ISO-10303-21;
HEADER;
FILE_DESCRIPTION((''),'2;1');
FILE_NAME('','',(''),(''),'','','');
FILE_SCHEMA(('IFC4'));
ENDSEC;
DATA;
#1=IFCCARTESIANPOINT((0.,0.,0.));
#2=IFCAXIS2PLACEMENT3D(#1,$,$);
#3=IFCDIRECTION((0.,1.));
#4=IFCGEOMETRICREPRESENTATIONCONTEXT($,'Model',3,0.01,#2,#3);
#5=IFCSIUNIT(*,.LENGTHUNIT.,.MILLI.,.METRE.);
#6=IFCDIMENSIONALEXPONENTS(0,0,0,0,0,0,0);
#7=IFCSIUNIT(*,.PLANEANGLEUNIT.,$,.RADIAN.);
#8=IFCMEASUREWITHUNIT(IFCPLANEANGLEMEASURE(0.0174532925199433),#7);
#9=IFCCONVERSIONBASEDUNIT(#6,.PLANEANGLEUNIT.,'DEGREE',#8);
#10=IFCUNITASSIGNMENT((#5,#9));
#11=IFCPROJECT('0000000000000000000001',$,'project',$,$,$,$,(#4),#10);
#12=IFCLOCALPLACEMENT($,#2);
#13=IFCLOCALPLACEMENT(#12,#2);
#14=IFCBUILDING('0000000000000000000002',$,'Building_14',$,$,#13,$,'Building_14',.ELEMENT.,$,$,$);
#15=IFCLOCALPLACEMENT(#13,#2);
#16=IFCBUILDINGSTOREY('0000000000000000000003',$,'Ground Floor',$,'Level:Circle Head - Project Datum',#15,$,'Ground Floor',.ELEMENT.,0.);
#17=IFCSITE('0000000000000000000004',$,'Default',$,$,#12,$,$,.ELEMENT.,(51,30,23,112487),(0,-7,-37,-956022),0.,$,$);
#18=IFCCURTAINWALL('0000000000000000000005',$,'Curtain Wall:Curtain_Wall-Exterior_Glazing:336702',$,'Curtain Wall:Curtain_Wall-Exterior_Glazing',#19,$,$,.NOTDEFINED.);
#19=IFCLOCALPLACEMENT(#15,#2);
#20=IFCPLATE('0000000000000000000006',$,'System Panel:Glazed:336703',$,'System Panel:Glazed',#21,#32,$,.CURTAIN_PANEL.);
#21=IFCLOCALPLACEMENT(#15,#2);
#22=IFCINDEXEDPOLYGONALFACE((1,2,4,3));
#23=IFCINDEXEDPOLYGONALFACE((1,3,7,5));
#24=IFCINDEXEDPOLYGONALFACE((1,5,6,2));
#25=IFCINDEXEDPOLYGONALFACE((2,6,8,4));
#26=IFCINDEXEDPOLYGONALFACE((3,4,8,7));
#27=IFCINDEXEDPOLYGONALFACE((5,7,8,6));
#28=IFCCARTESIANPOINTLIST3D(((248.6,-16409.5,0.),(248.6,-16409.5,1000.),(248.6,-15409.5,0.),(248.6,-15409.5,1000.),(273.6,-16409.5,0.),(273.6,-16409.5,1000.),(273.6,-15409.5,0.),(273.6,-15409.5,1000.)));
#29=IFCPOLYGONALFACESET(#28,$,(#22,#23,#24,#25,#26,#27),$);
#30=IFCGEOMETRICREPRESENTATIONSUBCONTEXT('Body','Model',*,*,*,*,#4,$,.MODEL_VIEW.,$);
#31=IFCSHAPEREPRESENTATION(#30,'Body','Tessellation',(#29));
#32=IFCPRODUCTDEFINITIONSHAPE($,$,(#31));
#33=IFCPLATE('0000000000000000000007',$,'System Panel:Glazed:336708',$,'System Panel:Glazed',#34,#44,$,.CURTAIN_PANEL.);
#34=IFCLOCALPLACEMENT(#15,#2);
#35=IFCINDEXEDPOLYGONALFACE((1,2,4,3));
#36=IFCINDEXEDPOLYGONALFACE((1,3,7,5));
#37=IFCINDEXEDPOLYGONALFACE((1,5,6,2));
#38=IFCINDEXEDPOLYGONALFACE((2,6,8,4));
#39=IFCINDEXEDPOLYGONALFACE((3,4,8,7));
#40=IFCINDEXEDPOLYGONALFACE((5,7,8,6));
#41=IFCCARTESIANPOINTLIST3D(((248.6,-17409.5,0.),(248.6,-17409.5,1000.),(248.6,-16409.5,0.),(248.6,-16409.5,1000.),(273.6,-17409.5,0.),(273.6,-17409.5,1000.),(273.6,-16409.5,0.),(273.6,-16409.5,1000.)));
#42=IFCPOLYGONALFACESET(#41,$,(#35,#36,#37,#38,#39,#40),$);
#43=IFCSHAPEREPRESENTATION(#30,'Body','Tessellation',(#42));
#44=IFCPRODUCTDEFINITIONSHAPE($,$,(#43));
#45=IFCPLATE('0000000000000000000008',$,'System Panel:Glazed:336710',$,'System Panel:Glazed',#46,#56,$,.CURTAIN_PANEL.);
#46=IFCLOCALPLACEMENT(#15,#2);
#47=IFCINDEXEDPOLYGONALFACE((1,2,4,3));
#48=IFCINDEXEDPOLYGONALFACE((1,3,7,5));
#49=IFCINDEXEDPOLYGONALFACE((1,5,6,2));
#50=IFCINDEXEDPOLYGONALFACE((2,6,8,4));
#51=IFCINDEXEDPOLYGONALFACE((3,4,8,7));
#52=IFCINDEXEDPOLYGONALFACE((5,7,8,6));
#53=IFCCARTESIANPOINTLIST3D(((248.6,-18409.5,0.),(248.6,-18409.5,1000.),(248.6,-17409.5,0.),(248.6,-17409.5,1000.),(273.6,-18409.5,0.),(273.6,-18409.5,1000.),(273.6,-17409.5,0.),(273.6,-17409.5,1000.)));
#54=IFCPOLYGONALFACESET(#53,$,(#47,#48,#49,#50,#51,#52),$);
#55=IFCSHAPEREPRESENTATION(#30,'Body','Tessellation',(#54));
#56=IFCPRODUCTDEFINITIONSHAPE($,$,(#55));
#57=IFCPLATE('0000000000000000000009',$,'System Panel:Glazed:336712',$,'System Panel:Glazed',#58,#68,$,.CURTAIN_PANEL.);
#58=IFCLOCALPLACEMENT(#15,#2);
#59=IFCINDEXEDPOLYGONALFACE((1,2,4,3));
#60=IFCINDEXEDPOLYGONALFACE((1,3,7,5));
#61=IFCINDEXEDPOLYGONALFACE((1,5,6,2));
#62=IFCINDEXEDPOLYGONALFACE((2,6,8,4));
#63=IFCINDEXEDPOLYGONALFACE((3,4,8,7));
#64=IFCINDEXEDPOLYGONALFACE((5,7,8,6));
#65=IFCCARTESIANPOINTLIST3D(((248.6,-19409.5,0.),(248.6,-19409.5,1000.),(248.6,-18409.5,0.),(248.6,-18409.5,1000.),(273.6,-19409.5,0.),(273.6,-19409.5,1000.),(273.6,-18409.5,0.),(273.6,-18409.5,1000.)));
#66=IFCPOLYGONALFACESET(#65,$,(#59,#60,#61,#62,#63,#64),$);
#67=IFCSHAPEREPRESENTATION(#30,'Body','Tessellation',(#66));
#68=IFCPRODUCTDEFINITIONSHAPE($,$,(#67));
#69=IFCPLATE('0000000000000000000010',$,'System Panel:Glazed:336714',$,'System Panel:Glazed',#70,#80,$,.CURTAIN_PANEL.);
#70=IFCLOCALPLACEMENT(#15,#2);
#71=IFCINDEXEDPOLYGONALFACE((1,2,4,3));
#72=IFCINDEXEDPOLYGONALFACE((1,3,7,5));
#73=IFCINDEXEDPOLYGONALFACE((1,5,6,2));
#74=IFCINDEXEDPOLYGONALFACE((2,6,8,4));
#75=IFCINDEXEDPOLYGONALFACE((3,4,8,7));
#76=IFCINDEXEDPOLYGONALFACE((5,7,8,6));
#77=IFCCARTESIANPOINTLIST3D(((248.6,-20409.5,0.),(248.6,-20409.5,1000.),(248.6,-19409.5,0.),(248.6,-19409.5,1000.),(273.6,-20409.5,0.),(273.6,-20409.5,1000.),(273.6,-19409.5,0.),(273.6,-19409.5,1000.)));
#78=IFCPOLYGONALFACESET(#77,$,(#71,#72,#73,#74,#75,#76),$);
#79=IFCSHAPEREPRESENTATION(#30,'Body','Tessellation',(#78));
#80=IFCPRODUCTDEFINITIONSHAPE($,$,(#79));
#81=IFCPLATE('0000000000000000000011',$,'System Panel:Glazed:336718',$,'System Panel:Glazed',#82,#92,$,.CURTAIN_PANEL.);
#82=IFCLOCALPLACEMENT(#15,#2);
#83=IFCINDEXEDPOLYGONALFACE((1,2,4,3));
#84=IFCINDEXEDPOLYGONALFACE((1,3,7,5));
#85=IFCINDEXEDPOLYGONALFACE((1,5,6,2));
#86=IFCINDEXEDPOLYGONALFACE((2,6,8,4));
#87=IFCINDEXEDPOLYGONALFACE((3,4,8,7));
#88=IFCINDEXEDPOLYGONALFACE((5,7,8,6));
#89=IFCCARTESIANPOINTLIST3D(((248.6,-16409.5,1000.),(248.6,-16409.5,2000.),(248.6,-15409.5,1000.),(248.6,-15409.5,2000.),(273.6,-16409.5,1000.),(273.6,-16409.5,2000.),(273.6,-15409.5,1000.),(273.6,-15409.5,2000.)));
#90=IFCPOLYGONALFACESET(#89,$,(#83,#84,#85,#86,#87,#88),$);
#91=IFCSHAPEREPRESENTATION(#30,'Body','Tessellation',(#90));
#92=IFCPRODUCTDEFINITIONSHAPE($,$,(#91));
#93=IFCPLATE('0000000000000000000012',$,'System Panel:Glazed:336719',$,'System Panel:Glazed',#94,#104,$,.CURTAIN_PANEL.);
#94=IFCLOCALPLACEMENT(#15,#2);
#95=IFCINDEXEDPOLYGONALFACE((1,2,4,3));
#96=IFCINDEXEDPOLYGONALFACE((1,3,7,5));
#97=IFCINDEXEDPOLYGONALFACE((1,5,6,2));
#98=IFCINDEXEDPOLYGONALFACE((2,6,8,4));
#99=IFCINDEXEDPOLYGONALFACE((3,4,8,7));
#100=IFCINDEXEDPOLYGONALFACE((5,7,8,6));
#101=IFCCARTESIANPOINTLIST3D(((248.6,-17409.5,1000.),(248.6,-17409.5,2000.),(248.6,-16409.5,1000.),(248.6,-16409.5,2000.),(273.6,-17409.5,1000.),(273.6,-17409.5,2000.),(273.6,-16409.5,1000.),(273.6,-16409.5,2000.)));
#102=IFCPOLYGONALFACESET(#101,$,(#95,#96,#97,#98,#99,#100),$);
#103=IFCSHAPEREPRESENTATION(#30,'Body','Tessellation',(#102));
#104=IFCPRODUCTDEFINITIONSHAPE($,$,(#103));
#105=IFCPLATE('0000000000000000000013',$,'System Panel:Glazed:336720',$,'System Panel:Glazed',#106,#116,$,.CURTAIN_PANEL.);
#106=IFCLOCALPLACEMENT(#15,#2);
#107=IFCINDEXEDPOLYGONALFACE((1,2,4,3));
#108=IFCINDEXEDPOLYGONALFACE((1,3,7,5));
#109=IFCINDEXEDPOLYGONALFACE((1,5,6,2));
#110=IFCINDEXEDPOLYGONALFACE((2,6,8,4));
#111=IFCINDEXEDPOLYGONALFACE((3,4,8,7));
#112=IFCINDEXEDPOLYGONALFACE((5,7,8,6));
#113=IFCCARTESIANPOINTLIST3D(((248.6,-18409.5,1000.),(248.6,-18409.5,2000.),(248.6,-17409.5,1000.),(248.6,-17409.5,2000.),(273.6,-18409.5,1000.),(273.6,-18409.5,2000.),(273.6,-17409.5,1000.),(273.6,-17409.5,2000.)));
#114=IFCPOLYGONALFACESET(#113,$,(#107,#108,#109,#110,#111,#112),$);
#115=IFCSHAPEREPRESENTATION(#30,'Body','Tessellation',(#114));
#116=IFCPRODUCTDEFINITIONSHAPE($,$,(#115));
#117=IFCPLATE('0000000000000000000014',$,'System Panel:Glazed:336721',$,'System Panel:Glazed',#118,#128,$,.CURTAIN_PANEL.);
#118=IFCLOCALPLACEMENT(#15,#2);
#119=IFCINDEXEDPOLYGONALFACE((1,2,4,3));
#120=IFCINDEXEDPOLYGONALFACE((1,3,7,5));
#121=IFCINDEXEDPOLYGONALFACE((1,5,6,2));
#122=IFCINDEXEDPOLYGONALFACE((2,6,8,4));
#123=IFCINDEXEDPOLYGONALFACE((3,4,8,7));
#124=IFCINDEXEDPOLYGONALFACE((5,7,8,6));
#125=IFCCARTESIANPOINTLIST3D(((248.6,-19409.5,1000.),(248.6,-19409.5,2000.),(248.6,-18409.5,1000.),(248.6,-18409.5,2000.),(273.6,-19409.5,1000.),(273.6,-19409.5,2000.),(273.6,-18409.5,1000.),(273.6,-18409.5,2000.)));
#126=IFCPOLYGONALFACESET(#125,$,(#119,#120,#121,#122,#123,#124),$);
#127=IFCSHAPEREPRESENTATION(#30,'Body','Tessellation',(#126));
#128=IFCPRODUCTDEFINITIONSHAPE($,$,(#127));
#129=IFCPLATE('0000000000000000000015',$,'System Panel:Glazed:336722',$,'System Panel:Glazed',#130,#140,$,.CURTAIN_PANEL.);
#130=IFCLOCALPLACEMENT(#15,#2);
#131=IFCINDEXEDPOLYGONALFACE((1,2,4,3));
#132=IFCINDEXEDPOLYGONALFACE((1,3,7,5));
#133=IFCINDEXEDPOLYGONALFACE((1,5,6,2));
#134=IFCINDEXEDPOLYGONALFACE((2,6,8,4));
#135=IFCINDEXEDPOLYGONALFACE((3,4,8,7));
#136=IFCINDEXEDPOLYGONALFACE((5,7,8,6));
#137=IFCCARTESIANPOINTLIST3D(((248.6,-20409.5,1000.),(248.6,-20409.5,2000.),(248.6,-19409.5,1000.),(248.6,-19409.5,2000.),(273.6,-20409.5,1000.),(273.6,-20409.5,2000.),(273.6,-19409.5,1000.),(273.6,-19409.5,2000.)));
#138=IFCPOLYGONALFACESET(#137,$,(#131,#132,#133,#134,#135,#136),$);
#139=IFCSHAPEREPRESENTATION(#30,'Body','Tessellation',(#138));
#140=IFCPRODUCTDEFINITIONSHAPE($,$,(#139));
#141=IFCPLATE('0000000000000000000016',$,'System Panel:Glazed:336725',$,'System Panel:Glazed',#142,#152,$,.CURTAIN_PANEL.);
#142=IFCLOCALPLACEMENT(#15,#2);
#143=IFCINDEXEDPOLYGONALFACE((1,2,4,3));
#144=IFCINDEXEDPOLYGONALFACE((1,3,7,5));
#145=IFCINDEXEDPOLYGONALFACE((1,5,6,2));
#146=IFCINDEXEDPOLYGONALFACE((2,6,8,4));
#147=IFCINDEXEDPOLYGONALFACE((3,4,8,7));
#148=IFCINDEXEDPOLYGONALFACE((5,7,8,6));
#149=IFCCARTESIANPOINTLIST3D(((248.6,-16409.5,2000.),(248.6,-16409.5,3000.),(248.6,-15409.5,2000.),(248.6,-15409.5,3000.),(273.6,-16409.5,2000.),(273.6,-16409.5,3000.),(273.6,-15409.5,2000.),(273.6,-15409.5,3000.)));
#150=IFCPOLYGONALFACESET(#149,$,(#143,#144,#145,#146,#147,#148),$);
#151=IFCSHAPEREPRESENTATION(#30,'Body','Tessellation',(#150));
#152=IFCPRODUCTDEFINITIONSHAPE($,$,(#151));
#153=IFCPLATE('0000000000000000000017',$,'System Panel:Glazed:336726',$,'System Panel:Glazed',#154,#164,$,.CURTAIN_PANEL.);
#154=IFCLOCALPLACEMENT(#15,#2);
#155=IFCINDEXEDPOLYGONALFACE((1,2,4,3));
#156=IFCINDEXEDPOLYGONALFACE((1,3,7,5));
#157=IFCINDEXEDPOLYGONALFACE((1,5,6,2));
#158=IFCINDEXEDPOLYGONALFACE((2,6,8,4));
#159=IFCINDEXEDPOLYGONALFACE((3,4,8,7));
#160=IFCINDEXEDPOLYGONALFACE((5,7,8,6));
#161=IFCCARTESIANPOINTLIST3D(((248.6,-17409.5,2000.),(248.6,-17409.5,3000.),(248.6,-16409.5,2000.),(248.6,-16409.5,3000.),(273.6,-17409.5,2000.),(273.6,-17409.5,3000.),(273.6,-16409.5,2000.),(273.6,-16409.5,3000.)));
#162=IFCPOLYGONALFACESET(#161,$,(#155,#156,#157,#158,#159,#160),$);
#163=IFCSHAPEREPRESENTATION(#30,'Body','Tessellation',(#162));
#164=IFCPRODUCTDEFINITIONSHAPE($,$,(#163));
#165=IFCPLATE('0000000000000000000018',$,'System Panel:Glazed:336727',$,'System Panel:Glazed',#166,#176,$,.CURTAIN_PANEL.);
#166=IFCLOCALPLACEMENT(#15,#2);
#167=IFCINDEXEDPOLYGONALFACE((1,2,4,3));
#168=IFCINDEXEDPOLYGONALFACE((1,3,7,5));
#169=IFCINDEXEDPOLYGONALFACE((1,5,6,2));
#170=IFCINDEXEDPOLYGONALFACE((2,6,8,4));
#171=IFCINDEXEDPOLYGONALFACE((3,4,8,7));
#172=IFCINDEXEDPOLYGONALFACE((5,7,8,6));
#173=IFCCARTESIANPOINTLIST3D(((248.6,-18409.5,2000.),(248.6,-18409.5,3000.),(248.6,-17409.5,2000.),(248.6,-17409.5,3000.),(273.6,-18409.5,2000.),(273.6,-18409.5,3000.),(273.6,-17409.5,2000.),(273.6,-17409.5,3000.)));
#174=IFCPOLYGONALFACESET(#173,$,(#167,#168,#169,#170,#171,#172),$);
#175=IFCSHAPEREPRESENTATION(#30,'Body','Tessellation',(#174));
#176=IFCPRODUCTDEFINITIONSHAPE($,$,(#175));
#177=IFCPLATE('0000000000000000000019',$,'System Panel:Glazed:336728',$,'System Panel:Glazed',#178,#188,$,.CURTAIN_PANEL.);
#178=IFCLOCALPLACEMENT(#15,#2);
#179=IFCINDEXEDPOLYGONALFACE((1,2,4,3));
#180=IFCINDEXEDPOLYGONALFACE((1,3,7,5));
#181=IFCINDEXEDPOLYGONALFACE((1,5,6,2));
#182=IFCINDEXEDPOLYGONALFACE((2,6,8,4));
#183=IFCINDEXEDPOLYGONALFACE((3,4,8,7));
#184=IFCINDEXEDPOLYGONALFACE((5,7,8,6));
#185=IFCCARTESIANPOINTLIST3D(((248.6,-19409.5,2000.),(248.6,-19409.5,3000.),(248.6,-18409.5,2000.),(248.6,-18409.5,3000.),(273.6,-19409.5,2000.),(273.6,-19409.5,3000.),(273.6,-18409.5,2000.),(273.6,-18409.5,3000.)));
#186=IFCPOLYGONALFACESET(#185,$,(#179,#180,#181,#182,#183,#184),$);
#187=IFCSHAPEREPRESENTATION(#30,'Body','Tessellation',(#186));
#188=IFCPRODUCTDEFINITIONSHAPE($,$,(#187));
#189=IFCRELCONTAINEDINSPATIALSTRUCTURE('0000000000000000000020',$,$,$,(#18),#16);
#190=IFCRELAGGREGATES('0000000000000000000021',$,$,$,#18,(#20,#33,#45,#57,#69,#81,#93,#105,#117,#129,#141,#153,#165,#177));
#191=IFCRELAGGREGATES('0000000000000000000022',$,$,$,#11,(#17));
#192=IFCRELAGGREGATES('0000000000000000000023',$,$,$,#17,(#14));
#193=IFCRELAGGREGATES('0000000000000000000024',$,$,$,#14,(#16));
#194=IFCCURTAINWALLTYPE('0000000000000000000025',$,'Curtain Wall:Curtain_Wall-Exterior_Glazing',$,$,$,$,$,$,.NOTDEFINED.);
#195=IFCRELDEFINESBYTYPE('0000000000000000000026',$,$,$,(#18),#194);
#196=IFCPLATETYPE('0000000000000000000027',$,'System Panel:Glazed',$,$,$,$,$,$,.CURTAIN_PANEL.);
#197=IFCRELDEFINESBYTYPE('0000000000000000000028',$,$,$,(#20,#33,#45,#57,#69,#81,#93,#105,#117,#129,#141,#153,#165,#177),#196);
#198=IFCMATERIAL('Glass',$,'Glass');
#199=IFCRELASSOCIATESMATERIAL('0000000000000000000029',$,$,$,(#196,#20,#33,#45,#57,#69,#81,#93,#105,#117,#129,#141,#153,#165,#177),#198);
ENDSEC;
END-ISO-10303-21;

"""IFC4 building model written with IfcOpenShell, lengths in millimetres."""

from ifc_helpers import new_model, entity, si_unit, converted_unit, direction, frame, origin, place, context, subcontext, project, spatial, indexed_curve, outline, extrude, source, transform, mapped, material, type_object, type_shapes, element, aggregate, save


model = new_model("IFC4")

# Units and contexts
model_context = context("Model", 3, precision=0.01, world=origin(), true_north=direction((0.0, 1.0)))
body_context = subcontext(model_context, "Body", "Model", "MODEL_VIEW")
ifc_project = project(units=[si_unit("LENGTHUNIT", "METRE", prefix="MILLI"), converted_unit("PLANEANGLEUNIT", "DEGREE", entity("IfcPlaneAngleMeasure", 0.0174532925199433), si_unit("PLANEANGLEUNIT", "RADIAN"), dimensions=[0, 0, 0, 0, 0, 0, 0])], contexts=[model_context])

# Site, building, storey
site_placement = place(None, origin())
site = spatial("IfcSite", under=ifc_project, at=site_placement, Name="Default", CompositionType="ELEMENT", RefLatitude=(51, 30, 23, 112487), RefLongitude=(0, -7, -37, -956022), RefElevation=0.0)
building_placement = place(site_placement, origin())
building = spatial("IfcBuilding", under=site, at=building_placement, Name="Building_14", LongName="Building_14", CompositionType="ELEMENT")
storey_placement = place(building_placement, origin())
storey = spatial("IfcBuildingStorey", under=building, at=storey_placement, Name="Ground Floor", ObjectType="Level:Circle Head - Project Datum", LongName="Ground Floor", CompositionType="ELEMENT", Elevation=0.0)

# Curtain wall, plates
curtain_wall_type = type_object("IfcCurtainWallType", Name="Curtain Wall:Curtain_Wall-Exterior_Glazing", PredefinedType="NOTDEFINED")
curtain_wall_1_placement = place(storey_placement, origin())
curtain_wall_1 = element("IfcCurtainWall", 1, at=curtain_wall_1_placement, inside=storey, type_object=curtain_wall_type, Name="Curtain Wall:Curtain_Wall-Exterior_Glazing:336702", ObjectType="Curtain Wall:Curtain_Wall-Exterior_Glazing", PredefinedType="NOTDEFINED")
ifc_material = material(Name="Glass", Category="Glass")
plate_type_1 = type_object("IfcPlateType", Name="System Panel:Glazed", PredefinedType="CURTAIN_PANEL", material=ifc_material)
shared_shape_1 = source(origin(), body_context, "Body", "SweptSolid", [
    extrude(outline(indexed_curve([(-12.5, -500.0), (12.5, -500.0), (12.5, 500.0), (-12.5, 500.0), (-12.5, -500.0)], self_intersect=False)), frame((0.0, -37.0, 0.0), z_axis=(0.0, 0.0, 1.0), x_axis=(0.0, 1.0, 0.0)), (0.0, 0.0, 1.0), 1000.0),
])
type_shapes(plate_type_1, [shared_shape_1])
plate_1_placement = place(curtain_wall_1_placement, frame((298.1, -15909.5, 0.0), z_axis=(0.0, 0.0, 1.0), x_axis=(0.0, -1.0, 0.0)))
plate_1 = element("IfcPlate", 2, at=plate_1_placement, type_object=plate_type_1, material=ifc_material, Name="System Panel:Glazed:336703", ObjectType="System Panel:Glazed", PredefinedType="CURTAIN_PANEL", context=body_context, shape_type="MappedRepresentation", body=[
    mapped(shared_shape_1, transform((0.0, 0.0, 0.0), scale=1.0)),
])
plate_2_placement = place(curtain_wall_1_placement, frame((298.1, -16909.5, 0.0), z_axis=(0.0, 0.0, 1.0), x_axis=(0.0, -1.0, 0.0)))
plate_2 = element("IfcPlate", 3, at=plate_2_placement, type_object=plate_type_1, material=ifc_material, Name="System Panel:Glazed:336708", ObjectType="System Panel:Glazed", PredefinedType="CURTAIN_PANEL", context=body_context, shape_type="MappedRepresentation", body=[
    mapped(shared_shape_1, transform((0.0, 0.0, 0.0), scale=1.0)),
])
plate_3_placement = place(curtain_wall_1_placement, frame((298.1, -17909.5, 0.0), z_axis=(0.0, 0.0, 1.0), x_axis=(0.0, -1.0, 0.0)))
plate_3 = element("IfcPlate", 4, at=plate_3_placement, type_object=plate_type_1, material=ifc_material, Name="System Panel:Glazed:336710", ObjectType="System Panel:Glazed", PredefinedType="CURTAIN_PANEL", context=body_context, shape_type="MappedRepresentation", body=[
    mapped(shared_shape_1, transform((0.0, 0.0, 0.0), scale=1.0)),
])
plate_4_placement = place(curtain_wall_1_placement, frame((298.1, -18909.5, 0.0), z_axis=(0.0, 0.0, 1.0), x_axis=(0.0, -1.0, 0.0)))
plate_4 = element("IfcPlate", 5, at=plate_4_placement, type_object=plate_type_1, material=ifc_material, Name="System Panel:Glazed:336712", ObjectType="System Panel:Glazed", PredefinedType="CURTAIN_PANEL", context=body_context, shape_type="MappedRepresentation", body=[
    mapped(shared_shape_1, transform((0.0, 0.0, 0.0), scale=1.0)),
])
plate_5_placement = place(curtain_wall_1_placement, frame((298.1, -19909.5, 0.0), z_axis=(0.0, 0.0, 1.0), x_axis=(0.0, -1.0, 0.0)))
plate_5 = element("IfcPlate", 6, at=plate_5_placement, type_object=plate_type_1, material=ifc_material, Name="System Panel:Glazed:336714", ObjectType="System Panel:Glazed", PredefinedType="CURTAIN_PANEL", context=body_context, shape_type="MappedRepresentation", body=[
    mapped(shared_shape_1, transform((0.0, 0.0, 0.0), scale=1.0)),
])
plate_6_placement = place(curtain_wall_1_placement, frame((298.1, -15909.5, 1000.0), z_axis=(0.0, 0.0, 1.0), x_axis=(0.0, -1.0, 0.0)))
plate_6 = element("IfcPlate", 7, at=plate_6_placement, type_object=plate_type_1, material=ifc_material, Name="System Panel:Glazed:336718", ObjectType="System Panel:Glazed", PredefinedType="CURTAIN_PANEL", context=body_context, shape_type="MappedRepresentation", body=[
    mapped(shared_shape_1, transform((0.0, 0.0, 0.0), scale=1.0)),
])
plate_7_placement = place(curtain_wall_1_placement, frame((298.1, -16909.5, 1000.0), z_axis=(0.0, 0.0, 1.0), x_axis=(0.0, -1.0, 0.0)))
plate_7 = element("IfcPlate", 8, at=plate_7_placement, type_object=plate_type_1, material=ifc_material, Name="System Panel:Glazed:336719", ObjectType="System Panel:Glazed", PredefinedType="CURTAIN_PANEL", context=body_context, shape_type="MappedRepresentation", body=[
    mapped(shared_shape_1, transform((0.0, 0.0, 0.0), scale=1.0)),
])
plate_8_placement = place(curtain_wall_1_placement, frame((298.1, -17909.5, 1000.0), z_axis=(0.0, 0.0, 1.0), x_axis=(0.0, -1.0, 0.0)))
plate_8 = element("IfcPlate", 9, at=plate_8_placement, type_object=plate_type_1, material=ifc_material, Name="System Panel:Glazed:336720", ObjectType="System Panel:Glazed", PredefinedType="CURTAIN_PANEL", context=body_context, shape_type="MappedRepresentation", body=[
    mapped(shared_shape_1, transform((0.0, 0.0, 0.0), scale=1.0)),
])
plate_9_placement = place(curtain_wall_1_placement, frame((298.1, -18909.5, 1000.0), z_axis=(0.0, 0.0, 1.0), x_axis=(0.0, -1.0, 0.0)))
plate_9 = element("IfcPlate", 10, at=plate_9_placement, type_object=plate_type_1, material=ifc_material, Name="System Panel:Glazed:336721", ObjectType="System Panel:Glazed", PredefinedType="CURTAIN_PANEL", context=body_context, shape_type="MappedRepresentation", body=[
    mapped(shared_shape_1, transform((0.0, 0.0, 0.0), scale=1.0)),
])
plate_10_placement = place(curtain_wall_1_placement, frame((298.1, -19909.5, 1000.0), z_axis=(0.0, 0.0, 1.0), x_axis=(0.0, -1.0, 0.0)))
plate_10 = element("IfcPlate", 11, at=plate_10_placement, type_object=plate_type_1, material=ifc_material, Name="System Panel:Glazed:336722", ObjectType="System Panel:Glazed", PredefinedType="CURTAIN_PANEL", context=body_context, shape_type="MappedRepresentation", body=[
    mapped(shared_shape_1, transform((0.0, 0.0, 0.0), scale=1.0)),
])
plate_11_placement = place(curtain_wall_1_placement, frame((298.1, -15909.5, 2000.0), z_axis=(0.0, 0.0, 1.0), x_axis=(0.0, -1.0, 0.0)))
plate_11 = element("IfcPlate", 12, at=plate_11_placement, type_object=plate_type_1, material=ifc_material, Name="System Panel:Glazed:336725", ObjectType="System Panel:Glazed", PredefinedType="CURTAIN_PANEL", context=body_context, shape_type="MappedRepresentation", body=[
    mapped(shared_shape_1, transform((0.0, 0.0, 0.0), scale=1.0)),
])
plate_12_placement = place(curtain_wall_1_placement, frame((298.1, -16909.5, 2000.0), z_axis=(0.0, 0.0, 1.0), x_axis=(0.0, -1.0, 0.0)))
plate_12 = element("IfcPlate", 13, at=plate_12_placement, type_object=plate_type_1, material=ifc_material, Name="System Panel:Glazed:336726", ObjectType="System Panel:Glazed", PredefinedType="CURTAIN_PANEL", context=body_context, shape_type="MappedRepresentation", body=[
    mapped(shared_shape_1, transform((0.0, 0.0, 0.0), scale=1.0)),
])
plate_13_placement = place(curtain_wall_1_placement, frame((298.1, -17909.5, 2000.0), z_axis=(0.0, 0.0, 1.0), x_axis=(0.0, -1.0, 0.0)))
plate_13 = element("IfcPlate", 14, at=plate_13_placement, type_object=plate_type_1, material=ifc_material, Name="System Panel:Glazed:336727", ObjectType="System Panel:Glazed", PredefinedType="CURTAIN_PANEL", context=body_context, shape_type="MappedRepresentation", body=[
    mapped(shared_shape_1, transform((0.0, 0.0, 0.0), scale=1.0)),
])
plate_14_placement = place(curtain_wall_1_placement, frame((298.1, -18909.5, 2000.0), z_axis=(0.0, 0.0, 1.0), x_axis=(0.0, -1.0, 0.0)))
plate_14 = element("IfcPlate", 15, at=plate_14_placement, type_object=plate_type_1, material=ifc_material, Name="System Panel:Glazed:336728", ObjectType="System Panel:Glazed", PredefinedType="CURTAIN_PANEL", context=body_context, shape_type="MappedRepresentation", body=[
    mapped(shared_shape_1, transform((0.0, 0.0, 0.0), scale=1.0)),
])

aggregate(curtain_wall_1, [plate_1, plate_2, plate_3, plate_4, plate_5, plate_6, plate_7, plate_8, plate_9, plate_10, plate_11, plate_12, plate_13, plate_14])

save(model, "model.ifc")
